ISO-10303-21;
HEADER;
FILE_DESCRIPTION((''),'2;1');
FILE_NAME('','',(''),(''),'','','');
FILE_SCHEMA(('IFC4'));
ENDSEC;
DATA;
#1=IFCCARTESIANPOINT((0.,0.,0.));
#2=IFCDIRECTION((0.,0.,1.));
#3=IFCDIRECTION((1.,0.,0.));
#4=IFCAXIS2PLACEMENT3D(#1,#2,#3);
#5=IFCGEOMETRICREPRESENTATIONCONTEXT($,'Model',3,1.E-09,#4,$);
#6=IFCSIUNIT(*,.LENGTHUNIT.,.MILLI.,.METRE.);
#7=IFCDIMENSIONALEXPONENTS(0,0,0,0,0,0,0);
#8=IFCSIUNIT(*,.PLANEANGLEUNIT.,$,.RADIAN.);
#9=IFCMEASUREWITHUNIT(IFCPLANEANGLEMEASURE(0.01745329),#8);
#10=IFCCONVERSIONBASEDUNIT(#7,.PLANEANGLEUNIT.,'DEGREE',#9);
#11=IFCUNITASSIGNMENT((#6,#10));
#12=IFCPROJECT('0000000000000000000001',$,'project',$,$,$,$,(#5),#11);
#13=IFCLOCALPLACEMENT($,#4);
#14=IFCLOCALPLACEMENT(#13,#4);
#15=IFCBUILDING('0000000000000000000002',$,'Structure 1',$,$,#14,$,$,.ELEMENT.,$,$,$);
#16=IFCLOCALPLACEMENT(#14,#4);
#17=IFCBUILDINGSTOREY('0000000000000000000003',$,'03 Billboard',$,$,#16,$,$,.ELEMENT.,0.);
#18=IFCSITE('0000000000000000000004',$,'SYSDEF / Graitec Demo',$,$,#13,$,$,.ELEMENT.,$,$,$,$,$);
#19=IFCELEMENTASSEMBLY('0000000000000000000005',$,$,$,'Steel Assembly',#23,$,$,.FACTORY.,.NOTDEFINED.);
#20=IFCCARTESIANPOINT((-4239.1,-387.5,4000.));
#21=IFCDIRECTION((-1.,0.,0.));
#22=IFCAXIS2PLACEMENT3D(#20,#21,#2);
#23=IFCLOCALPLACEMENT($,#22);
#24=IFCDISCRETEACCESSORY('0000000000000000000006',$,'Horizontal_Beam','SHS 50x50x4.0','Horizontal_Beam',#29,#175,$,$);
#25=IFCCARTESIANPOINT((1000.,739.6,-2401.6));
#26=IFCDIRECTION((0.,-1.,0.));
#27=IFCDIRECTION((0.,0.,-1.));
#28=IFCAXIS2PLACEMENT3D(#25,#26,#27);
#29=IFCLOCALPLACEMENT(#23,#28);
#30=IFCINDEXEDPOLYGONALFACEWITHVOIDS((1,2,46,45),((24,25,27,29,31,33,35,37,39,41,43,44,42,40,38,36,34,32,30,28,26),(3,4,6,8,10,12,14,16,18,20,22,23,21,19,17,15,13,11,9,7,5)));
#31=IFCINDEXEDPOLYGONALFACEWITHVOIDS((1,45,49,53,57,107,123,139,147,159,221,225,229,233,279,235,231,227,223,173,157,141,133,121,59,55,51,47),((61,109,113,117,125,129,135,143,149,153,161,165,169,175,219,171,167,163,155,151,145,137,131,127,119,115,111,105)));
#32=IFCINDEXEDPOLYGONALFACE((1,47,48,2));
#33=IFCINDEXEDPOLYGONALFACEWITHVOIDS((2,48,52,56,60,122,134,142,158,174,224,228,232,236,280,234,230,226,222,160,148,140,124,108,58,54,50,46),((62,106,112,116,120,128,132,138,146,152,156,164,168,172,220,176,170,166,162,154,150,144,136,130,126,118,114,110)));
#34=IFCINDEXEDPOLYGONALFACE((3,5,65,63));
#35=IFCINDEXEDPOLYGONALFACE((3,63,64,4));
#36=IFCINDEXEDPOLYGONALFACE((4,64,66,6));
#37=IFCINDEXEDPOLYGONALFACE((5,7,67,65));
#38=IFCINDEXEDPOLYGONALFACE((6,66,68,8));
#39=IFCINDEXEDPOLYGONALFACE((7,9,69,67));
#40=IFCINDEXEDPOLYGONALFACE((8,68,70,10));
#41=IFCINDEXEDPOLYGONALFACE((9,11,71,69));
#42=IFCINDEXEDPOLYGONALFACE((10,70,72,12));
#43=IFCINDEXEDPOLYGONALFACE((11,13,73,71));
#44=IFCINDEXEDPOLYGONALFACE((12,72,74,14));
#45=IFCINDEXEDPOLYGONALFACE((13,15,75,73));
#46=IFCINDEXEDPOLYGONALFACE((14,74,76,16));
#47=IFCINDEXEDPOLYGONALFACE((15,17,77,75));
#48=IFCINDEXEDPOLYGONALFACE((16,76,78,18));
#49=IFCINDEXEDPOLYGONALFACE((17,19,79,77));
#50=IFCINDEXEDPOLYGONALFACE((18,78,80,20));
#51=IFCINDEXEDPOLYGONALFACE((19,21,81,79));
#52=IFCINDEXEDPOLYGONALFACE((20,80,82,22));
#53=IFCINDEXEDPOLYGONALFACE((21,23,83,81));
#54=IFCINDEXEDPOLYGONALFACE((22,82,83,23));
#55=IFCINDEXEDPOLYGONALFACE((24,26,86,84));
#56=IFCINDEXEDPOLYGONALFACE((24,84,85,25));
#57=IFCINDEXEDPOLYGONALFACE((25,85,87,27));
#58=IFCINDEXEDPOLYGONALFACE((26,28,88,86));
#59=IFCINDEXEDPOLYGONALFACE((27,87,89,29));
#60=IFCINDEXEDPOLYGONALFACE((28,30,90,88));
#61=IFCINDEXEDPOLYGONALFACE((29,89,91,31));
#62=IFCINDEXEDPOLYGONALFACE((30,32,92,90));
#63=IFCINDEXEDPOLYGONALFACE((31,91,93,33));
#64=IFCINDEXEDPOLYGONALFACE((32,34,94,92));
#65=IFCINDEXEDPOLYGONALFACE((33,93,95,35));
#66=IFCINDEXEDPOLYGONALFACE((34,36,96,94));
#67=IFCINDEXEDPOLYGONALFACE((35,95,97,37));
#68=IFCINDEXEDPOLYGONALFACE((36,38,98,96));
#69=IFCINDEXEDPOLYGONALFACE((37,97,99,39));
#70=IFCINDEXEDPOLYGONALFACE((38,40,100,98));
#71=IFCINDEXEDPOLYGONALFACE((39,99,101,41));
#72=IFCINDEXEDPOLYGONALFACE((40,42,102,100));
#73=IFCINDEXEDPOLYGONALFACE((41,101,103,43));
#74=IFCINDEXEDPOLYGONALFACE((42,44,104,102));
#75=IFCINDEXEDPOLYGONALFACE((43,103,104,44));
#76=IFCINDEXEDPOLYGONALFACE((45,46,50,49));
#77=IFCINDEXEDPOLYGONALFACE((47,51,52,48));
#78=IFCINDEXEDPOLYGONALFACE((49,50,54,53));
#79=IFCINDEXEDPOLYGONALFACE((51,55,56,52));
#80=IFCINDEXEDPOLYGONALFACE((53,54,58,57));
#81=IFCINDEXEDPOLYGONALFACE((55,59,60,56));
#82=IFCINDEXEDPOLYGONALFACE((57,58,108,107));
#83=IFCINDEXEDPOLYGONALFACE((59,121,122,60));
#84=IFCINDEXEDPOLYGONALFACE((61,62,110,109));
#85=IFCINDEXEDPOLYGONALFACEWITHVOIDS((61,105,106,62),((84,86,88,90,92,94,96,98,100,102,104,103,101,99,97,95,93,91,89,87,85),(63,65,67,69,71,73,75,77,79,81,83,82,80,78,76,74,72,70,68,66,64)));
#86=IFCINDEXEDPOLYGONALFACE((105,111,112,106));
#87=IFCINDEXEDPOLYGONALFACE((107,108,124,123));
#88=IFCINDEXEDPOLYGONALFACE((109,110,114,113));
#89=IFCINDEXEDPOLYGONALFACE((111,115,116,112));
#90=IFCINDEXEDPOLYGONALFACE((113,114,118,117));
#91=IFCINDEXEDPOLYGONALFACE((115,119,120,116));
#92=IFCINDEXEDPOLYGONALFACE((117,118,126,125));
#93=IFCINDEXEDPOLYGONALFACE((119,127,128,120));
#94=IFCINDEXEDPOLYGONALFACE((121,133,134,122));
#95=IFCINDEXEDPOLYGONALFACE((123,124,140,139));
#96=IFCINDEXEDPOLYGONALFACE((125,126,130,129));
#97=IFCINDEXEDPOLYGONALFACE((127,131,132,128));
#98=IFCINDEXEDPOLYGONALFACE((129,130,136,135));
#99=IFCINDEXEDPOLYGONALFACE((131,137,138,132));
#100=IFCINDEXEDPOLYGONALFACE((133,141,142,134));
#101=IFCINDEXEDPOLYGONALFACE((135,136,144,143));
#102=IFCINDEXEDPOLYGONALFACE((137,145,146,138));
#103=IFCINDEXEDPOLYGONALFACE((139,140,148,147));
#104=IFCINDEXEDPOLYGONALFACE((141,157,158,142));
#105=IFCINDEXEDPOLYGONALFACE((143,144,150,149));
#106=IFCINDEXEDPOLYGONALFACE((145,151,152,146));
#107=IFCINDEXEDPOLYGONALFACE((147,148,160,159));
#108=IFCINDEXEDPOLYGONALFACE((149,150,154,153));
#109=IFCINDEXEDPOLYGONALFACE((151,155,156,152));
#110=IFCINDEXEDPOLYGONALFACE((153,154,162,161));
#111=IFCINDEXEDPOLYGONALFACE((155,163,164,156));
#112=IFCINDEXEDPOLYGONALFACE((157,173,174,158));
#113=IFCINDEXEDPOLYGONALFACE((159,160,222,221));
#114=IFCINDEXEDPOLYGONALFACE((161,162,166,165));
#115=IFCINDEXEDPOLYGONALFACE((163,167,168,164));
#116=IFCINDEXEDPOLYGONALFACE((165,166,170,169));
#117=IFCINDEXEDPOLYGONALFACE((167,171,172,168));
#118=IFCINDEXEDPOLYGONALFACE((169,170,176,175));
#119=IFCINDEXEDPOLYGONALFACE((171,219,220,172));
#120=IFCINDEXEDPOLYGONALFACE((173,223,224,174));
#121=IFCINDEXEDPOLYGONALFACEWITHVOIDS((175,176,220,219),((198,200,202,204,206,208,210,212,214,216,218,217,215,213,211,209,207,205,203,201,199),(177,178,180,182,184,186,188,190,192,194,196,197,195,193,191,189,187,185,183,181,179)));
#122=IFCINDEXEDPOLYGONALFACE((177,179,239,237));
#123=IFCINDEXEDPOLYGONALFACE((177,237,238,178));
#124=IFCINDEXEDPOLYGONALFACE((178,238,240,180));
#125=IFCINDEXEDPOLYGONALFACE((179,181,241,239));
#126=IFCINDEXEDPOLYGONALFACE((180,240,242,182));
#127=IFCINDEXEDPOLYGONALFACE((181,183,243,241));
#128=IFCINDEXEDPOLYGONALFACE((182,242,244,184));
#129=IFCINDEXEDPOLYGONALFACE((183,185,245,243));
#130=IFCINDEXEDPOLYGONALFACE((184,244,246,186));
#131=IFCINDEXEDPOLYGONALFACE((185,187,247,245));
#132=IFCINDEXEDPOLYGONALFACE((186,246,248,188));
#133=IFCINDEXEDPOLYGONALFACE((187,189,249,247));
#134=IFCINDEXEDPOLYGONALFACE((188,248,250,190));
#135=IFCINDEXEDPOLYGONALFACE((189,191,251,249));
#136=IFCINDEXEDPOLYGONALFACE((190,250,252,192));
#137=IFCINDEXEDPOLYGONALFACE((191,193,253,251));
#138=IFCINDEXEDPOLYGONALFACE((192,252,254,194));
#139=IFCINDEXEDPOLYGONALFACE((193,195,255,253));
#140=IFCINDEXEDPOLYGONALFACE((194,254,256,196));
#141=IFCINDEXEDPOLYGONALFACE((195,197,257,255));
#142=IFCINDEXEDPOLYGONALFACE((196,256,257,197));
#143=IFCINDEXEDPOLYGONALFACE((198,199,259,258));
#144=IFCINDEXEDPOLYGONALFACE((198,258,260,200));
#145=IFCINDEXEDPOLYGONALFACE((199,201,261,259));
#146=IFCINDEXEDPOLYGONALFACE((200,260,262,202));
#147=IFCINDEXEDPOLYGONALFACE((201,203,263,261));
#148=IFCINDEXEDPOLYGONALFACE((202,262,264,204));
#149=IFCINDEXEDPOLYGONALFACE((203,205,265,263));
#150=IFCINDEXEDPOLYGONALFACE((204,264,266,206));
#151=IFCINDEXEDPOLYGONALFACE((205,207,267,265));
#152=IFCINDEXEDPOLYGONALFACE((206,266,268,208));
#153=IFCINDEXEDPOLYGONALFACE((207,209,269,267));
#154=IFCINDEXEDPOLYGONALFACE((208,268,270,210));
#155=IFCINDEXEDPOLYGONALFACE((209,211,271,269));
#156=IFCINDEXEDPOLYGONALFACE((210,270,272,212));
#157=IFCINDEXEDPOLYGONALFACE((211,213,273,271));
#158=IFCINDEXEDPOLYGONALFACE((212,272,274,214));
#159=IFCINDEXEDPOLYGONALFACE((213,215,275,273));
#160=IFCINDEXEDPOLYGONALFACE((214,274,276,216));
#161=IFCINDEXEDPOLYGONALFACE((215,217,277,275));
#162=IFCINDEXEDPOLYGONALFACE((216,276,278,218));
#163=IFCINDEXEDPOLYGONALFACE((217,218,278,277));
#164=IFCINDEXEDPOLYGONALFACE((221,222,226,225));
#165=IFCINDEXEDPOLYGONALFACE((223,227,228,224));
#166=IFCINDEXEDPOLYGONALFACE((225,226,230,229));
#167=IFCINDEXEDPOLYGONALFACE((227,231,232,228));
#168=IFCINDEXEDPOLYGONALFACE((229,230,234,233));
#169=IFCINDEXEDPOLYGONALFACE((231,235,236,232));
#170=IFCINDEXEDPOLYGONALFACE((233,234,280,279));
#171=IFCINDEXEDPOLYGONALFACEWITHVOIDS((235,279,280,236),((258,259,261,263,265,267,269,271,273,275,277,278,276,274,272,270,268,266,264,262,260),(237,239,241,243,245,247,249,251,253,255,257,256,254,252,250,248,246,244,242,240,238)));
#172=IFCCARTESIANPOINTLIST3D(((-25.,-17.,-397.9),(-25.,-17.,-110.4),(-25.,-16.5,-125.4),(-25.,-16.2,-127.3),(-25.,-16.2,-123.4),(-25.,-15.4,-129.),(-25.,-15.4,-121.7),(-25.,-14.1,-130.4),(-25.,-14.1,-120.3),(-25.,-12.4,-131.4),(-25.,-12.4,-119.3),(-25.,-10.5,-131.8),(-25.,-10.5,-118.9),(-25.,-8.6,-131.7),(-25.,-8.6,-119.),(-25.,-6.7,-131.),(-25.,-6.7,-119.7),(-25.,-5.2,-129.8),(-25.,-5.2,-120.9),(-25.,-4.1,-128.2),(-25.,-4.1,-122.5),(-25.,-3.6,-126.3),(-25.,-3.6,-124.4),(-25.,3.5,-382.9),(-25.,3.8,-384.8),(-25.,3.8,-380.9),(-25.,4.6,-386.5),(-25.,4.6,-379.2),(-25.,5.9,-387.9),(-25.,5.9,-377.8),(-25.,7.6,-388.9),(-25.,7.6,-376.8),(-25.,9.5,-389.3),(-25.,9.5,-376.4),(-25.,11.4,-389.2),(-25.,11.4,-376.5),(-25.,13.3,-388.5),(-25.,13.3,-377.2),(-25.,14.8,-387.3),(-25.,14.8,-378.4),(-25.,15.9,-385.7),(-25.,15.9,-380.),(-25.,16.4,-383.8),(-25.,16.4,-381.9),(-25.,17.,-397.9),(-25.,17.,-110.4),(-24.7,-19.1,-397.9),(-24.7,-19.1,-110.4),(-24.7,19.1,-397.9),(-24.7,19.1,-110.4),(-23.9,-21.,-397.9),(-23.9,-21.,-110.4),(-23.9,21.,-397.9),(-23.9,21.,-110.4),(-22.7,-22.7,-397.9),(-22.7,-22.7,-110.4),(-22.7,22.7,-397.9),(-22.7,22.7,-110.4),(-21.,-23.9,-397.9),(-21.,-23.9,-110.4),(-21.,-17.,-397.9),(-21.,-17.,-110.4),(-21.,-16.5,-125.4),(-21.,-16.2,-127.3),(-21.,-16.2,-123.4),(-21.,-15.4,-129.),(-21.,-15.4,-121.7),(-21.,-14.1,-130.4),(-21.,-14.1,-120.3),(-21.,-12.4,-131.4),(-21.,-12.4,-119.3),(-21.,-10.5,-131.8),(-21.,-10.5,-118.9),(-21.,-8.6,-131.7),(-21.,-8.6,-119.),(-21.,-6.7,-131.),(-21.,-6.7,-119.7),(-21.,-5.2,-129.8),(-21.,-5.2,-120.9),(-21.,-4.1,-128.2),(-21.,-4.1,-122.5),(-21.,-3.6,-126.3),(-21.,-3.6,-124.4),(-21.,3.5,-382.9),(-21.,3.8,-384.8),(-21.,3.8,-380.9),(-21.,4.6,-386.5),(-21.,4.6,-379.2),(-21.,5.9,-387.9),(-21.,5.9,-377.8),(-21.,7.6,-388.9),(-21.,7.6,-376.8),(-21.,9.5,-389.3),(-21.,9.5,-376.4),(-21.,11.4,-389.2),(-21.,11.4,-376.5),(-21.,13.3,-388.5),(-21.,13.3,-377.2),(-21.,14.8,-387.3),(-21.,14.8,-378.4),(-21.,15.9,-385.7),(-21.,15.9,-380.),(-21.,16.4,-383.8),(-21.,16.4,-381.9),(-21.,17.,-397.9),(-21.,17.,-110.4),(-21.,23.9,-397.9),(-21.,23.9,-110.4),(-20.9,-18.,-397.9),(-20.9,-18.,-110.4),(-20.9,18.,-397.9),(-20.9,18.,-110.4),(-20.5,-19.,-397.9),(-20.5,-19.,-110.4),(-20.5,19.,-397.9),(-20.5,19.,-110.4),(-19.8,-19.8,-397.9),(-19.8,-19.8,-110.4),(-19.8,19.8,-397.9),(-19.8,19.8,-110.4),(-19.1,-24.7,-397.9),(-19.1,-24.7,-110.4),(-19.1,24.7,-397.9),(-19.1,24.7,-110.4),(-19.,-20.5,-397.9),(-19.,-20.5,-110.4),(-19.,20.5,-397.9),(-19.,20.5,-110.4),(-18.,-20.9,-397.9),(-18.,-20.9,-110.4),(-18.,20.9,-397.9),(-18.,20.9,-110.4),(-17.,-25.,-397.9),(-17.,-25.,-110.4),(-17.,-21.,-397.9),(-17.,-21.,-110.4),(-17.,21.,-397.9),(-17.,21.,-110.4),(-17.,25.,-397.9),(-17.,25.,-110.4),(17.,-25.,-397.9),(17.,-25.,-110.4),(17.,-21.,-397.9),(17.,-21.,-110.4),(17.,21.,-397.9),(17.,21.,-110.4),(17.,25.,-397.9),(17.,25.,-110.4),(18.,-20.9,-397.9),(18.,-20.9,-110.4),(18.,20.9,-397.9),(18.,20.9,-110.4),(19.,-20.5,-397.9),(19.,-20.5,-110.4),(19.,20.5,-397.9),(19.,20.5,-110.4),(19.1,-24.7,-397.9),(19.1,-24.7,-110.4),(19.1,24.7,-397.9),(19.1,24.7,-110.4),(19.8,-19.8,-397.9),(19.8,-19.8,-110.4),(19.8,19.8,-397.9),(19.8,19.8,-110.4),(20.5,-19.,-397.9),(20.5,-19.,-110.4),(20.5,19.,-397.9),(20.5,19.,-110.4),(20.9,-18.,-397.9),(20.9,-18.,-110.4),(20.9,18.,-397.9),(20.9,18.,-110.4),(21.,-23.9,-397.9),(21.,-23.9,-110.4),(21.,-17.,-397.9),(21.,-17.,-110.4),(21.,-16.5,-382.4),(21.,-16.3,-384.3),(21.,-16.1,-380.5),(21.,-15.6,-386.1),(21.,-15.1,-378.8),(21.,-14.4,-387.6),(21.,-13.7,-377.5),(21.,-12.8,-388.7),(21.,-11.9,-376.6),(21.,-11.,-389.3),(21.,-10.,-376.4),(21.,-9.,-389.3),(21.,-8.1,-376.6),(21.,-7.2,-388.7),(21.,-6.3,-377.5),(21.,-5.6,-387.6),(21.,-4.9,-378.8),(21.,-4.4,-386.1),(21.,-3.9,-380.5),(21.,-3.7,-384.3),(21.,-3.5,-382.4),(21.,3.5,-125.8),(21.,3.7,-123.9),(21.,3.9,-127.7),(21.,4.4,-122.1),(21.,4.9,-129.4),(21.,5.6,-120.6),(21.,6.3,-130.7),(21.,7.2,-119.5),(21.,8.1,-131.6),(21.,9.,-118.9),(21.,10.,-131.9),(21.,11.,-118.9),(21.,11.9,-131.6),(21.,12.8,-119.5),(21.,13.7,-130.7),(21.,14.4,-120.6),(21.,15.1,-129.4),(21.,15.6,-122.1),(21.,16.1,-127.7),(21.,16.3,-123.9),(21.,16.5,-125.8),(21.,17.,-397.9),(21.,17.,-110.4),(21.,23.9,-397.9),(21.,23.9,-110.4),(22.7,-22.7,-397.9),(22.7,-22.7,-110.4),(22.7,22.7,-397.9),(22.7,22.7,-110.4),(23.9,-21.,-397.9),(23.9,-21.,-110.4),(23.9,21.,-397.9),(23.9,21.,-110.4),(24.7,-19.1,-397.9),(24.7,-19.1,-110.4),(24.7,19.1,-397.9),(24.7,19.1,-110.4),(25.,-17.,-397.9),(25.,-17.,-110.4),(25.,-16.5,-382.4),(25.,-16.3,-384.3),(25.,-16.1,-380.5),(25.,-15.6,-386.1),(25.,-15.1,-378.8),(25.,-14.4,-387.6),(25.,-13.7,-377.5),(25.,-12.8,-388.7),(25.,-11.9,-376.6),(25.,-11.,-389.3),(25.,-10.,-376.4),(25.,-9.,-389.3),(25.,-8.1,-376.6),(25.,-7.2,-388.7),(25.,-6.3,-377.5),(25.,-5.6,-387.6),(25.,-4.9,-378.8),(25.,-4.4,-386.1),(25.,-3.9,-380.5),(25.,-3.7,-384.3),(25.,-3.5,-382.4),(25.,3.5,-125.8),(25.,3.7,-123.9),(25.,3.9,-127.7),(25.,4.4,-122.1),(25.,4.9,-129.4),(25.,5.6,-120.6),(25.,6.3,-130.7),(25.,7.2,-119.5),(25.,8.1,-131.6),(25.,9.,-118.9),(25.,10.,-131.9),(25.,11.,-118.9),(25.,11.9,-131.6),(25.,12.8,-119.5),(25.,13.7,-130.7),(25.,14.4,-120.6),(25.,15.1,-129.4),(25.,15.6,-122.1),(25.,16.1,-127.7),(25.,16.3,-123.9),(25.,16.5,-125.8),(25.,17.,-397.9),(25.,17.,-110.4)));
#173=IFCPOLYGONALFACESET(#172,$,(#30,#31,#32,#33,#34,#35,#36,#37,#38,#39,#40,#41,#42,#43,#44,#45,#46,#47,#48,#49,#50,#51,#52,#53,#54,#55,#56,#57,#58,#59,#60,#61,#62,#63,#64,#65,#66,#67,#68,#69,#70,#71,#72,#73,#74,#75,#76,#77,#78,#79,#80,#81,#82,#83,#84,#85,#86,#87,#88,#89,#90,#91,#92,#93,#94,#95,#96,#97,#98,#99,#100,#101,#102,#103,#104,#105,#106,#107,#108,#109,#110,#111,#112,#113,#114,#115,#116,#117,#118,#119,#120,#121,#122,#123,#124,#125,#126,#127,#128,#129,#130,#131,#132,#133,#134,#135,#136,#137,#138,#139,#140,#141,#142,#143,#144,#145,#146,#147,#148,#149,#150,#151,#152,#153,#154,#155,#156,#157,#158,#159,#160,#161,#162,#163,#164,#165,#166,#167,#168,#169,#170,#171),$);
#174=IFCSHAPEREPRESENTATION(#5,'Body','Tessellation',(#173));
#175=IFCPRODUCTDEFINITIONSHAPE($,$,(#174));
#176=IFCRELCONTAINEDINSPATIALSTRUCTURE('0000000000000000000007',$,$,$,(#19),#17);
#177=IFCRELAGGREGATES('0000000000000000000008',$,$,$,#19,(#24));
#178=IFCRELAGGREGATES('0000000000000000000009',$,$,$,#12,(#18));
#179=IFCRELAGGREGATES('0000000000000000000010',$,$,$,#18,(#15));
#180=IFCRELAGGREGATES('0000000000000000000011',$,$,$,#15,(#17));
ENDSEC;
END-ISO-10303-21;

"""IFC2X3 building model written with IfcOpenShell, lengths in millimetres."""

from ifc_helpers import new_model, entity, si_unit, converted_unit, frame, frame_2d, origin, origin_with_axes, origin_2d, origin_2d_with_axis, place, context, project, spatial, hollow_rectangle, circle, extrude, clip, halfspace, element, aggregate, save


model = new_model("IFC2X3")

# Units and contexts
model_context = context("Model", 3, precision=1e-09, world=origin_with_axes())
ifc_project = project(units=[si_unit("LENGTHUNIT", "METRE", prefix="MILLI"), converted_unit("PLANEANGLEUNIT", "DEGREE", entity("IfcPlaneAngleMeasure", 0.01745329), si_unit("PLANEANGLEUNIT", "RADIAN"), dimensions=[0, 0, 0, 0, 0, 0, 0])], contexts=[model_context])

# Site, building, storey
site_placement = place(None, origin_with_axes())
site = spatial("IfcSite", under=ifc_project, at=site_placement, Name="SYSDEF / Graitec Demo", CompositionType="ELEMENT")
building_placement = place(site_placement, origin_with_axes())
building = spatial("IfcBuilding", under=site, at=building_placement, Name="Structure 1", CompositionType="ELEMENT")
storey_placement = place(building_placement, origin_with_axes())
storey = spatial("IfcBuildingStorey", under=building, at=storey_placement, Name="03 Billboard", CompositionType="ELEMENT", Elevation=0.0)

# Element assembly, discrete accessory, openings
assembly_1_placement = place(None, frame((-4239.1, -387.5, 4000.0), z_axis=(-1.0, 0.0, 0.0), x_axis=(0.0, 0.0, 1.0)))
assembly_1 = element("IfcElementAssembly", 1, at=assembly_1_placement, inside=storey, ObjectType="Steel Assembly", AssemblyPlace="FACTORY", PredefinedType="NOTDEFINED")
discrete_accessory_1_placement = place(assembly_1_placement, frame((1000.0, 739.6, -2401.6), z_axis=(0.0, -1.0, 0.0), x_axis=(0.0, 0.0, -1.0)))
discrete_accessory_1 = element("IfcDiscreteAccessory", 2, at=discrete_accessory_1_placement, Name="Horizontal_Beam", Description="SHS 50x50x4.0", ObjectType="Horizontal_Beam", context=model_context, shape_type="Clipping", body=[
    clip(clip(extrude(hollow_rectangle(XDim=50.0, YDim=50.0, WallThickness=4.0, InnerFilletRadius=4.0, OuterFilletRadius=8.0, at=origin_2d()), origin(), (0.0, 0.0, -1.0), 483.2), halfspace(frame((1837.5, -5000.0, -110.4), z_axis=(0.0, 0.0, -1.0), x_axis=(-1.0, 0.0, 0.0)), True)), halfspace(frame((1837.5, -5000.0, -397.9), z_axis=(0.0, 0.0, 1.0), x_axis=(1.0, 0.0, 0.0)), True)),
])
opening_1_placement = place(discrete_accessory_1_placement, frame((20.5, -10.0, -382.9), z_axis=(1.0, 0.0, 0.0), x_axis=(0.0, 0.0, 1.0)))
element("IfcOpeningElement", 3, at=opening_1_placement, cuts=discrete_accessory_1, ObjectType="Opening", context=model_context, shape_type="SweptSolid", body=[
    extrude(circle(Radius=6.5, at=origin_2d_with_axis()), origin(), (0.0, 0.0, 1.0), 5.0),
])
opening_2_placement = place(discrete_accessory_1_placement, frame((20.5, 10.0, -125.4), z_axis=(1.0, 0.0, 0.0), x_axis=(0.0, 0.0, -1.0)))
element("IfcOpeningElement", 4, at=opening_2_placement, cuts=discrete_accessory_1, ObjectType="Opening", context=model_context, shape_type="SweptSolid", body=[
    extrude(circle(Radius=6.5, at=origin_2d_with_axis()), origin(), (0.0, 0.0, 1.0), 5.0),
])
opening_3_placement = place(discrete_accessory_1_placement, frame((-25.5, -10.0, -118.9), z_axis=(-1.0, 0.0, 0.0), x_axis=(0.0, -1.0, 0.0)))
element("IfcOpeningElement", 5, at=opening_3_placement, cuts=discrete_accessory_1, ObjectType="Opening", context=model_context, shape_type="SweptSolid", body=[
    extrude(circle(Radius=6.5, at=frame_2d((0.0, -6.5), x_axis=(1.0, 0.0))), origin(), (0.0, 0.0, -1.0), 5.0),
])
opening_4_placement = place(discrete_accessory_1_placement, frame((-25.5, 10.0, -389.4), z_axis=(-1.0, 0.0, 0.0), x_axis=(0.0, -1.0, 0.0)))
element("IfcOpeningElement", 6, at=opening_4_placement, cuts=discrete_accessory_1, ObjectType="Opening", context=model_context, shape_type="SweptSolid", body=[
    extrude(circle(Radius=6.5, at=frame_2d((0.0, 6.5), x_axis=(1.0, 0.0))), origin(), (0.0, 0.0, -1.0), 5.0),
])
aggregate(assembly_1, [discrete_accessory_1])

save(model, "model.ifc")
